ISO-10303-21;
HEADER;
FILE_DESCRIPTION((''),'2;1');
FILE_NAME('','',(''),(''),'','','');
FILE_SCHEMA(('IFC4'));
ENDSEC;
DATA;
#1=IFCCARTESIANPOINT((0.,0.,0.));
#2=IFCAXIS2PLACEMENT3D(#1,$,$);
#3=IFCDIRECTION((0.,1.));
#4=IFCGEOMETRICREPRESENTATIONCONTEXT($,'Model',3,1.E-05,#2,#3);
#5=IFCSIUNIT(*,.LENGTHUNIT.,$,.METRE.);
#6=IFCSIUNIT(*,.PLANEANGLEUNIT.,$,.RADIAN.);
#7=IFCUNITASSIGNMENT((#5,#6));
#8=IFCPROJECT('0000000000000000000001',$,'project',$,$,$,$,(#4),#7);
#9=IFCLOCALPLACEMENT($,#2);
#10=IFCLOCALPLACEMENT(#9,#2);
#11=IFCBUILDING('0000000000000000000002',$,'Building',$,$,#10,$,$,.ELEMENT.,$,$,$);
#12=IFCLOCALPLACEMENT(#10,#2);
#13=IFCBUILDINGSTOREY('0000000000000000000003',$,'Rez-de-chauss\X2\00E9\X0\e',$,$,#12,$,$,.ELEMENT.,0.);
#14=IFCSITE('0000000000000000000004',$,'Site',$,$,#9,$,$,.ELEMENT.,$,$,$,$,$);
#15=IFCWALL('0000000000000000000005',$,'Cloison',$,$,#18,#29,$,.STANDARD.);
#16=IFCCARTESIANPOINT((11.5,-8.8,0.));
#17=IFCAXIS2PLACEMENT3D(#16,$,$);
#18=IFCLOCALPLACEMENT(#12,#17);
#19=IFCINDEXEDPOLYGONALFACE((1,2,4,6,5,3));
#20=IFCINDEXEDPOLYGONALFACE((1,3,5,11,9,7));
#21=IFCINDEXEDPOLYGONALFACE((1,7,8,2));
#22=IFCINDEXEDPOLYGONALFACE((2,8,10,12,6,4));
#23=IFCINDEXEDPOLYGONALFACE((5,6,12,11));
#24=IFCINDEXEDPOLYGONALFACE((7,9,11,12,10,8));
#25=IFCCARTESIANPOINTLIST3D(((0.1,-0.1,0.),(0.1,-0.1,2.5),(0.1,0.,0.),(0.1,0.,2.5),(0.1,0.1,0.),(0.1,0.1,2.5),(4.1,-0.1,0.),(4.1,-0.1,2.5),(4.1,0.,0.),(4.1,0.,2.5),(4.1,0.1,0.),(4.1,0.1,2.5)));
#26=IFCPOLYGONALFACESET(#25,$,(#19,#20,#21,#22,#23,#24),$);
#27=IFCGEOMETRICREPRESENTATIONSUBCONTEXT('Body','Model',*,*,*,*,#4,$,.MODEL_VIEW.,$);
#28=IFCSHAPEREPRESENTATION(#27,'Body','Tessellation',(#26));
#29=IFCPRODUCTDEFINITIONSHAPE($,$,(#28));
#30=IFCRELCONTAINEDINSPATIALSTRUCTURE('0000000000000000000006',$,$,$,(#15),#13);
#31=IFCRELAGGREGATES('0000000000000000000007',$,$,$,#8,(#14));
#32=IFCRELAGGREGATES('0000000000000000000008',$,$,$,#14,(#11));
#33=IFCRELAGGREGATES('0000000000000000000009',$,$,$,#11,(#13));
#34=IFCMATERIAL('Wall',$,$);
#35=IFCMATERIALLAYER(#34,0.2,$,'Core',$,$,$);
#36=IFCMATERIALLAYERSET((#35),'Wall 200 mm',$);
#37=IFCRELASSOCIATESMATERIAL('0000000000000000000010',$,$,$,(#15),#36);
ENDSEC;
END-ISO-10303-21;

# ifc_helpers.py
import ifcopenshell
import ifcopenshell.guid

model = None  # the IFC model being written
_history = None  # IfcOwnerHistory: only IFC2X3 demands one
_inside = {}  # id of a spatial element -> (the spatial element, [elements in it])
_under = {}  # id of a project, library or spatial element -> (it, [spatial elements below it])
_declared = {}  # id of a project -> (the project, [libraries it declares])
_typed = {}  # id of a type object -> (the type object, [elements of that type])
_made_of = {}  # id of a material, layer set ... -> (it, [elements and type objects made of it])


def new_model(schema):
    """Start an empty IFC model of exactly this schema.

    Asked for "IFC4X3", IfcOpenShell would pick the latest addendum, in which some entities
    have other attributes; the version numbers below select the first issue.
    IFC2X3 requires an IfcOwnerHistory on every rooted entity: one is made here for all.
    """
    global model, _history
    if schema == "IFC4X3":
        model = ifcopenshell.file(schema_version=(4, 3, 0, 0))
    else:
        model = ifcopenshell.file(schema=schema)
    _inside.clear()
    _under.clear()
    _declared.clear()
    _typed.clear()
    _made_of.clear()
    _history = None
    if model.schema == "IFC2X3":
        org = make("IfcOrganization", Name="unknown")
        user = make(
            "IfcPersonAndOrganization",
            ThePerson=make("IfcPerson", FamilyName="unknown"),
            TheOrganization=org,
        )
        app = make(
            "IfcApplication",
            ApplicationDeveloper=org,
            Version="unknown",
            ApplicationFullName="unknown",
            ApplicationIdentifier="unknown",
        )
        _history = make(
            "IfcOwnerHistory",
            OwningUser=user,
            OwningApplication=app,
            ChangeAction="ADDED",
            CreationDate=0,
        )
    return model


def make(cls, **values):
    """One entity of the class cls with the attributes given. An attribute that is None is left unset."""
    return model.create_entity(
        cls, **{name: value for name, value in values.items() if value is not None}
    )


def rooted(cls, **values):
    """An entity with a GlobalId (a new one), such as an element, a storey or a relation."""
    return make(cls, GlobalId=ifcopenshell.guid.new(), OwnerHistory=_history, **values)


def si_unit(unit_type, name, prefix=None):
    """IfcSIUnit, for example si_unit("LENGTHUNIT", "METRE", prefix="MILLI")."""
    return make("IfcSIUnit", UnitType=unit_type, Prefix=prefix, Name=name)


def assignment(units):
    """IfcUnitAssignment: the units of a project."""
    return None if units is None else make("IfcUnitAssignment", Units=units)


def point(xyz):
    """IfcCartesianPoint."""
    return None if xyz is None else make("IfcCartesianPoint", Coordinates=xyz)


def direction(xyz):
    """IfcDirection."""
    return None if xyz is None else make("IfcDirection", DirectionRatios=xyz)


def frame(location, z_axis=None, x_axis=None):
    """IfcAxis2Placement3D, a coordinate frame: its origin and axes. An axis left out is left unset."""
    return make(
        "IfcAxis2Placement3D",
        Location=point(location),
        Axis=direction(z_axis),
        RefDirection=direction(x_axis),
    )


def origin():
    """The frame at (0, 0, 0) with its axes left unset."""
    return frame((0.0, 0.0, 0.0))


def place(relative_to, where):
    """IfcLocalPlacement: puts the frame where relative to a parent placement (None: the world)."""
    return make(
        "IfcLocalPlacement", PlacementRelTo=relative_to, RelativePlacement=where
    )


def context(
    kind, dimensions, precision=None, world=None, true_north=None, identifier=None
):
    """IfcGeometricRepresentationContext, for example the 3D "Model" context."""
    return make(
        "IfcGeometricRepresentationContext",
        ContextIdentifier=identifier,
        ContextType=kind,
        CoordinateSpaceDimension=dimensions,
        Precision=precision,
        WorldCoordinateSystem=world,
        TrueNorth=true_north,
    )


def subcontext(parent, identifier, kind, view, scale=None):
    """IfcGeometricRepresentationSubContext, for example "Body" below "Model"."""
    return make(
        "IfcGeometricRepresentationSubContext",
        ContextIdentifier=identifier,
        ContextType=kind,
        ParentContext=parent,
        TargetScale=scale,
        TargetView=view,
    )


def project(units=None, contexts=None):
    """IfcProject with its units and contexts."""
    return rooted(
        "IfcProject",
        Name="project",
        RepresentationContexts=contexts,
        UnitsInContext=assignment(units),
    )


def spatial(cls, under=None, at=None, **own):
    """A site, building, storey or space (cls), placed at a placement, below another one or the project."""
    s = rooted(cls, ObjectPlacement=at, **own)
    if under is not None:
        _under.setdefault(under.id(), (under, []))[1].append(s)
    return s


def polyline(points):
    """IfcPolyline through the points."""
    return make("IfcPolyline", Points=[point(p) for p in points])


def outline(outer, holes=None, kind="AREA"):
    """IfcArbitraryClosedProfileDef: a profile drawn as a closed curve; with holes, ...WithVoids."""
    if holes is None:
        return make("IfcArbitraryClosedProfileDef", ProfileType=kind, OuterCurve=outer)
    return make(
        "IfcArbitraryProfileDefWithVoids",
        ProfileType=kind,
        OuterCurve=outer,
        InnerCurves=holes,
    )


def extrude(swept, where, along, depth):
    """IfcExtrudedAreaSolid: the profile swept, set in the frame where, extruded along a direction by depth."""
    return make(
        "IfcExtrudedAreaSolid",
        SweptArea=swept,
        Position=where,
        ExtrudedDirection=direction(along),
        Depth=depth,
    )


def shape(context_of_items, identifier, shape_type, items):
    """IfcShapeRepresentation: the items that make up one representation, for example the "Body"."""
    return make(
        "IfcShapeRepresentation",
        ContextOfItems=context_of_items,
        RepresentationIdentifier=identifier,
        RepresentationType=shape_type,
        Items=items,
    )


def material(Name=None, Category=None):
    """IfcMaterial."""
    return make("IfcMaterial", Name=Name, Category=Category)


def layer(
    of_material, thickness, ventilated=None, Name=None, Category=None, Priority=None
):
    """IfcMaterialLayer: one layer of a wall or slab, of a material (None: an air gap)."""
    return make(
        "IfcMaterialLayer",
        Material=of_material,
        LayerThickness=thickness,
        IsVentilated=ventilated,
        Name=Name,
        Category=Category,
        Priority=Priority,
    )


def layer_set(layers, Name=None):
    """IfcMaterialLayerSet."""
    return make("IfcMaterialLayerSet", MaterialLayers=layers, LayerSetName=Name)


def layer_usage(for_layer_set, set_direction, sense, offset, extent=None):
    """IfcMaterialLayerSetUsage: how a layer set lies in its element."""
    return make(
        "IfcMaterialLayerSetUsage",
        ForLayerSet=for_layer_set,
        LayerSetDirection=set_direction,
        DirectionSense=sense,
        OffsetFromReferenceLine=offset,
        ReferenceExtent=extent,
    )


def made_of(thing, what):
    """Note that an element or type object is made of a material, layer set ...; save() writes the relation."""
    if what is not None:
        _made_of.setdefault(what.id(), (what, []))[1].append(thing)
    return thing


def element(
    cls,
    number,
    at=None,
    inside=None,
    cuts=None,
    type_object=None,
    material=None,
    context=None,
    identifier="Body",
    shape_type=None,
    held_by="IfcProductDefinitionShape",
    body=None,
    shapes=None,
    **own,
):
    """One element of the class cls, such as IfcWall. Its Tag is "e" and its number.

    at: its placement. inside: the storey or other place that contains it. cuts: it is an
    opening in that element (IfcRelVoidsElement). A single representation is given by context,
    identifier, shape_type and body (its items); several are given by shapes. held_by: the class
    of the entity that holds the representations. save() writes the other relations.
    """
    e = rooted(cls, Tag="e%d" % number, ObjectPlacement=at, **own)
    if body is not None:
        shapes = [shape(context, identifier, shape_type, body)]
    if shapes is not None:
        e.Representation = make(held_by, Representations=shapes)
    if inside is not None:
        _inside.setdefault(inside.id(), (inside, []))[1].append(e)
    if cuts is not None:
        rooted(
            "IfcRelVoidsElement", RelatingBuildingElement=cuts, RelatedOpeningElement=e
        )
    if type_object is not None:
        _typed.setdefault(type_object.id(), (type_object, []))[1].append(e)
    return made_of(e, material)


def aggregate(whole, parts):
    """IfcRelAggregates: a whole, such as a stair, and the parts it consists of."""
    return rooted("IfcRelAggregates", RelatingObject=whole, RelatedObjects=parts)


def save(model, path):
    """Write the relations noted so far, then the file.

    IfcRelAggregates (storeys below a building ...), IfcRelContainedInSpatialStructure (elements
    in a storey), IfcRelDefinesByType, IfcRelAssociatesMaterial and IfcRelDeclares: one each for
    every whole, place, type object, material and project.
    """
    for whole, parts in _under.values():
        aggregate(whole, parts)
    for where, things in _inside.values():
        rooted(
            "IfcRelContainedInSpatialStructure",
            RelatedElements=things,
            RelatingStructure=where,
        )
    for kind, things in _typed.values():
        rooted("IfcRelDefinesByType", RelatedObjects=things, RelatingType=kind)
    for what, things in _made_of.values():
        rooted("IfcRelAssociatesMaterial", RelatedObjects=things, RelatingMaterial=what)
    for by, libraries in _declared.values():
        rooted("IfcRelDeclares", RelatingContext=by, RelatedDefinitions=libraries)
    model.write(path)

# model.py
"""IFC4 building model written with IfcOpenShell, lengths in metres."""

from ifc_helpers import new_model, si_unit, direction, frame, origin, place, context, subcontext, project, spatial, polyline, outline, extrude, material, layer, layer_set, layer_usage, element, save


model = new_model("IFC4")

# Units and contexts
model_context = context("Model", 3, precision=1e-05, world=origin(), true_north=direction((0.0, 1.0)))
body_context = subcontext(model_context, "Body", "Model", "MODEL_VIEW")
ifc_project = project(units=[si_unit("LENGTHUNIT", "METRE"), si_unit("PLANEANGLEUNIT", "RADIAN")], contexts=[model_context])

# Site, building, storey
site_placement = place(None, origin())
site = spatial("IfcSite", under=ifc_project, at=site_placement, Name="Site", CompositionType="ELEMENT")
building_placement = place(site_placement, origin())
building = spatial("IfcBuilding", under=site, at=building_placement, Name="Building", CompositionType="ELEMENT")
storey_placement = place(building_placement, origin())
storey = spatial("IfcBuildingStorey", under=building, at=storey_placement, Name="Rez-de-chaussée", CompositionType="ELEMENT", Elevation=0.0)

# Shared definitions
ifc_material = material(Name="Wall")
ifc_layer = layer(ifc_material, 0.2, Name="Core")
ifc_layer_set = layer_set([ifc_layer], Name="Wall 200 mm")
ifc_layer_usage = layer_usage(ifc_layer_set, "AXIS2", "POSITIVE", -0.1)

# Wall
wall_1_placement = place(storey_placement, frame((11.5, -8.8, 0.0)))
element("IfcWall", 1, at=wall_1_placement, inside=storey, material=ifc_layer_usage, Name="Cloison", PredefinedType="STANDARD", context=body_context, shape_type="SweptSolid", body=[
    extrude(outline(polyline([(0.1, 0.0), (0.1, -0.1), (4.1, -0.1), (4.1, 0.0), (4.1, 0.1), (0.1, 0.1), (0.1, 0.0)])), origin(), (0.0, 0.0, 1.0), 2.5),
])

save(model, "model.ifc")
